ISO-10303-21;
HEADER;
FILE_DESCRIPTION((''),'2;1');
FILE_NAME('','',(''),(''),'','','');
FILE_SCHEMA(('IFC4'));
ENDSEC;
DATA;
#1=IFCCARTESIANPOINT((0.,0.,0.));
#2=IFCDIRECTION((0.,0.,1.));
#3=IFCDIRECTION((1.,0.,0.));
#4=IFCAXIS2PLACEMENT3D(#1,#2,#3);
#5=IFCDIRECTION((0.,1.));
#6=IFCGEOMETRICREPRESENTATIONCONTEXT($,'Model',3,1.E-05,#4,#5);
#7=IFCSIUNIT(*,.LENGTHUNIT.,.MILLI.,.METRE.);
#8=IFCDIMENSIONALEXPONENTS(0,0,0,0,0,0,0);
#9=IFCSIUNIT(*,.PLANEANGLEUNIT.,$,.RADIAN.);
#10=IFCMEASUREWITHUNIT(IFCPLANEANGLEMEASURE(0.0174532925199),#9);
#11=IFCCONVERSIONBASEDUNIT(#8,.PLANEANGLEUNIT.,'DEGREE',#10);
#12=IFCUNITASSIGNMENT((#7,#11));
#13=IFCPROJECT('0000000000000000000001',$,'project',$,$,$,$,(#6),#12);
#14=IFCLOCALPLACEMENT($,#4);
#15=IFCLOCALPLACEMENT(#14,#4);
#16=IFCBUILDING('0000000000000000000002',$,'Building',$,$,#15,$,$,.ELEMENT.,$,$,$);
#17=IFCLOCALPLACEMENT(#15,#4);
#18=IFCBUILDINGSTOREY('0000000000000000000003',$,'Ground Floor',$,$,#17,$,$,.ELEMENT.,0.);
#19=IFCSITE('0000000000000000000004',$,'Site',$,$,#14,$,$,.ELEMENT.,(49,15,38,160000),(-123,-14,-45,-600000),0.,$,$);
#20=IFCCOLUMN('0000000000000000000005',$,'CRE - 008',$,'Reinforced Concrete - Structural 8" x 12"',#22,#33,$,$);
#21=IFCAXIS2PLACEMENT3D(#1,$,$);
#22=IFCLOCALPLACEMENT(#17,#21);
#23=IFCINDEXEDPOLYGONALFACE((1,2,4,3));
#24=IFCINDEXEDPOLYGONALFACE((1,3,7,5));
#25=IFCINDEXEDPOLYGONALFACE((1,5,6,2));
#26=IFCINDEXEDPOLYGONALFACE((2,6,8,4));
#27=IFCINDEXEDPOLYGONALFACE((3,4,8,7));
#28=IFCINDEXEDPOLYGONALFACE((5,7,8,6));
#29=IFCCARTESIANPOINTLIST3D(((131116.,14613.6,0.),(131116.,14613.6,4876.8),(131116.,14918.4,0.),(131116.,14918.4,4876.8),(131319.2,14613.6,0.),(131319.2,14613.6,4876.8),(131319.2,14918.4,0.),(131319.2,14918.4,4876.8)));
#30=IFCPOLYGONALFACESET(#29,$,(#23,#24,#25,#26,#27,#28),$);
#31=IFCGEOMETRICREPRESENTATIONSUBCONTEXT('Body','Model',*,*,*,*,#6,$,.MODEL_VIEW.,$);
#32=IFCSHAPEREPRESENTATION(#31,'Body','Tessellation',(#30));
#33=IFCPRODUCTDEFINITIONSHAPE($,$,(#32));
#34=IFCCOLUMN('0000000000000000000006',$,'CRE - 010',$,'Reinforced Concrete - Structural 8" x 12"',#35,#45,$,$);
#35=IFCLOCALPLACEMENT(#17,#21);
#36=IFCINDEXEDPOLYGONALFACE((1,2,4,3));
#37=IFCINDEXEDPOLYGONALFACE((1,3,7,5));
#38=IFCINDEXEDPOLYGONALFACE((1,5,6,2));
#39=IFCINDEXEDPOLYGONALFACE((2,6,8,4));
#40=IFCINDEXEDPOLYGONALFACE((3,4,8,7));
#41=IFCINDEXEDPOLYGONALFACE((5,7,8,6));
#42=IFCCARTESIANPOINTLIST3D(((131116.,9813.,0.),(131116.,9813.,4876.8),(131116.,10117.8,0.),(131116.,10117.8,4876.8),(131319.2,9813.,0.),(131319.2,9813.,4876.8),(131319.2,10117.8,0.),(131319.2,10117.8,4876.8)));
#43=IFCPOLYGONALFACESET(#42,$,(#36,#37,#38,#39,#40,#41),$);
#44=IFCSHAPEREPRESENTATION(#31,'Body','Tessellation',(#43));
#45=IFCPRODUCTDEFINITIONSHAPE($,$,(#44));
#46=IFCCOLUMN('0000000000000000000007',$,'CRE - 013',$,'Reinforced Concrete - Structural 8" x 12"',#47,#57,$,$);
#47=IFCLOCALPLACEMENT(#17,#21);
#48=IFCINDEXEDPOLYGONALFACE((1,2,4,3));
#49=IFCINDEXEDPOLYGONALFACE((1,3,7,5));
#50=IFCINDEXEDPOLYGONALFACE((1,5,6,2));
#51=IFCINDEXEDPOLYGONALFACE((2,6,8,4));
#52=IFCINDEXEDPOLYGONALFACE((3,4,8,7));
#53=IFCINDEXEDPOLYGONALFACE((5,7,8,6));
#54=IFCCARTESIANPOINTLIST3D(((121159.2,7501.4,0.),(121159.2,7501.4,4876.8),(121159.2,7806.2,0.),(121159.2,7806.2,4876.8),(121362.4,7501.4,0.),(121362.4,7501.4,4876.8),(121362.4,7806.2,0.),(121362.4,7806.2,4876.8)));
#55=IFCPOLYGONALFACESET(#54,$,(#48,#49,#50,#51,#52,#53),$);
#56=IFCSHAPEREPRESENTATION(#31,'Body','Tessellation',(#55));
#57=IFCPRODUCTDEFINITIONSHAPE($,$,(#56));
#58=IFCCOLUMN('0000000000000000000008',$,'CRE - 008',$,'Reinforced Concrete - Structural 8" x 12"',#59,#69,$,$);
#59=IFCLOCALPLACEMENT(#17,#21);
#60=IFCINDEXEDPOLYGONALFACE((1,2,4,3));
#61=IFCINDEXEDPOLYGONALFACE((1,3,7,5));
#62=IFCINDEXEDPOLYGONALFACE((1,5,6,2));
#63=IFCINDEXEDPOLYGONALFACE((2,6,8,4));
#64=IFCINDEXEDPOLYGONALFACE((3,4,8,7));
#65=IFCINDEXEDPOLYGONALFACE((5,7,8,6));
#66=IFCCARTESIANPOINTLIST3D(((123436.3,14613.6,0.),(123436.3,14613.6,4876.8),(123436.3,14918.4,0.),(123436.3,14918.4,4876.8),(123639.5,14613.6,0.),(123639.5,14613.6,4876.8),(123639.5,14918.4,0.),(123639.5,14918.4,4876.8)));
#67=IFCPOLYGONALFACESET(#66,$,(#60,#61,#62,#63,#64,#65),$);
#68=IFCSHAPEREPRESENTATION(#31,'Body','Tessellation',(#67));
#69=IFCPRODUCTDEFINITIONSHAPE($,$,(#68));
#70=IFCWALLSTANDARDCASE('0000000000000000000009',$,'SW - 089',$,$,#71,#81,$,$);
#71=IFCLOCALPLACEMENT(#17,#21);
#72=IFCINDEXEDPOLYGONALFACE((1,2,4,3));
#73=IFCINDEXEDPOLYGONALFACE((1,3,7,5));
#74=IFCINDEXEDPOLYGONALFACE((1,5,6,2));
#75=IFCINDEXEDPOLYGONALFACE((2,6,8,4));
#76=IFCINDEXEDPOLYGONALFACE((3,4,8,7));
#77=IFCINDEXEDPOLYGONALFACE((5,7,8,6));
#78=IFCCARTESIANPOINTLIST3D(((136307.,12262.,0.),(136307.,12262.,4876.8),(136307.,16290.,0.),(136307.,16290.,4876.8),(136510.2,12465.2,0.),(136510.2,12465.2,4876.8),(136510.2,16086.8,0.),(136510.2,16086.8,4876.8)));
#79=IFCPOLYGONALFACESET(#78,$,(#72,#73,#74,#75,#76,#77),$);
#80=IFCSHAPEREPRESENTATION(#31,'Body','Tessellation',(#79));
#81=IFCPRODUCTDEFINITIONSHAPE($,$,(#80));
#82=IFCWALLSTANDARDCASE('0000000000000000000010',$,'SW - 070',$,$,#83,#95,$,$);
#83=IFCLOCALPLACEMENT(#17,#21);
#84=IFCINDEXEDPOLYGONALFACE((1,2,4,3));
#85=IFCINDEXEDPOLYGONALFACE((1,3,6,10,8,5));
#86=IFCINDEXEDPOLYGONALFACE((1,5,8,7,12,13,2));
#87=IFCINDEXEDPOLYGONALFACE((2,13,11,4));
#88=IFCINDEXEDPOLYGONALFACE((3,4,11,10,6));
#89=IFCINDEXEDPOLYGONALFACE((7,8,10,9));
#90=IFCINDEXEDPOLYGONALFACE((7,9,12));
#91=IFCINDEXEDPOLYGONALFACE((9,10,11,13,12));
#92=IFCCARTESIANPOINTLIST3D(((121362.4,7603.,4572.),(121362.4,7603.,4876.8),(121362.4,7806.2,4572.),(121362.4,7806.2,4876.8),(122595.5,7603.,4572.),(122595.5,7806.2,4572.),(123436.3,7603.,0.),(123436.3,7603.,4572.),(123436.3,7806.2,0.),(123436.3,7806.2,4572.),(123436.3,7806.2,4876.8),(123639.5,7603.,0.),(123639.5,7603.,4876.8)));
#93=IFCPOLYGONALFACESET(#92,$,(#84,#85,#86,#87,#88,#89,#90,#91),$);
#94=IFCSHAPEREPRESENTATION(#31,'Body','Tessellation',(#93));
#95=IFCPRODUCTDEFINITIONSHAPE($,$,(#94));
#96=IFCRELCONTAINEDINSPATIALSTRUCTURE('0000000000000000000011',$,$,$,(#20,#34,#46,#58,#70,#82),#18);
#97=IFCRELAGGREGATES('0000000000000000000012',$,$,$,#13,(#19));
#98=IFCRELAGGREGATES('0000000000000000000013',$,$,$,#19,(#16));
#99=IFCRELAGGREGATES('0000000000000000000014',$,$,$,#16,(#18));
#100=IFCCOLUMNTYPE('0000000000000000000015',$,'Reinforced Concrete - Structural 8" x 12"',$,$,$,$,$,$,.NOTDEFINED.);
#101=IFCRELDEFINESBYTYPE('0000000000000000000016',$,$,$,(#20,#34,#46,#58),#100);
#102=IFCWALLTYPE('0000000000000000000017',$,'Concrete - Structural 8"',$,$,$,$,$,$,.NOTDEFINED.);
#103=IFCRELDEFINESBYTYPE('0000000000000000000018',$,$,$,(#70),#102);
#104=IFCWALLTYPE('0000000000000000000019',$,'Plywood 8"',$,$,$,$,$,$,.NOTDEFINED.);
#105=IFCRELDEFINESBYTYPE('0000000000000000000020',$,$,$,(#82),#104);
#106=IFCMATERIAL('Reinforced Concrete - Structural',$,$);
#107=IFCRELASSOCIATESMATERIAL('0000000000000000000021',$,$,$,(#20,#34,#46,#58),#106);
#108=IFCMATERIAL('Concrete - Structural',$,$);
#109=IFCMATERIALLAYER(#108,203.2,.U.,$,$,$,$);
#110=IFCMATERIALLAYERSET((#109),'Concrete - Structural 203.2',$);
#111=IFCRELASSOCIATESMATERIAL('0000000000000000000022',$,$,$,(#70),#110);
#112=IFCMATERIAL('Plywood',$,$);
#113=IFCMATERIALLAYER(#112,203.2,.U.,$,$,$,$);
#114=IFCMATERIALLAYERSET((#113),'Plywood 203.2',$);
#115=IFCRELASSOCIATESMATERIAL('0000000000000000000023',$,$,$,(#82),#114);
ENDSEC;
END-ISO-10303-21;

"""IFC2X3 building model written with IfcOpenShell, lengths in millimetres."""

from ifc_helpers import new_model, entity, si_unit, converted_unit, direction, frame, origin_with_axes, origin_2d_with_axis, place, context, subcontext, project, spatial, polyline, rectangle, outline, extrude, material, layer, layer_set, layer_usage, type_object, element, save


model = new_model("IFC2X3")

# Units and contexts
model_context = context("Model", 3, precision=1e-05, world=origin_with_axes(), true_north=direction((0.0, 1.0)))
body_context = subcontext(model_context, "Body", "Model", "MODEL_VIEW")
ifc_project = project(units=[si_unit("LENGTHUNIT", "METRE", prefix="MILLI"), converted_unit("PLANEANGLEUNIT", "DEGREE", entity("IfcPlaneAngleMeasure", 0.0174532925199), si_unit("PLANEANGLEUNIT", "RADIAN"), dimensions=[0, 0, 0, 0, 0, 0, 0])], contexts=[model_context])

# Site, building, storey
site_placement = place(None, origin_with_axes())
site = spatial("IfcSite", under=ifc_project, at=site_placement, Name="Site", CompositionType="ELEMENT", RefLatitude=(49, 15, 38, 160000), RefLongitude=(-123, -14, -45, -600000), RefElevation=0.0)
building_placement = place(site_placement, origin_with_axes())
building = spatial("IfcBuilding", under=site, at=building_placement, Name="Building", CompositionType="ELEMENT")
storey_placement = place(building_placement, origin_with_axes())
storey = spatial("IfcBuildingStorey", under=building, at=storey_placement, Name="Ground Floor", CompositionType="ELEMENT", Elevation=0.0)

# Columns
ifc_material_1 = material(Name="Reinforced Concrete - Structural")
column_type = type_object("IfcColumnType", Name="Reinforced Concrete - Structural 8\" x 12\"", PredefinedType="NOTDEFINED")
for number, where, z_axis, x_axis, name in (
    (1, (131217.6, 14766.0, 0.0), (0.0, 0.0, 1.0), (1.0, 0.0, 0.0), "CRE - 008"),
    (2, (131217.6, 9965.4, 0.0), (0.0, 0.0, 1.0), (1.0, 0.0, 0.0), "CRE - 010"),
    (3, (121260.8, 7653.8, 0.0), (0.0, 0.0, 1.0), (1.0, 0.0, 0.0), "CRE - 013"),
    (4, (123537.9, 14766.0, 0.0), (0.0, 0.0, 1.0), (1.0, 0.0, 0.0), "CRE - 008"),
):
    element("IfcColumn", number, at=place(storey_placement, frame(where, z_axis=z_axis, x_axis=x_axis)), inside=storey, type_object=column_type, material=ifc_material_1, Name=name, ObjectType="Reinforced Concrete - Structural 8\" x 12\"", context=body_context, shape_type="SweptSolid", body=[
        extrude(rectangle(XDim=203.2, YDim=304.8, at=origin_2d_with_axis()), origin_with_axes(), (0.0, 0.0, 1.0), 4876.8),
    ])

# Wall
ifc_material_2 = material(Name="Concrete - Structural")
ifc_layer_1 = layer(ifc_material_2, 203.2, ventilated="UNKNOWN")
ifc_layer_set_1 = layer_set([ifc_layer_1], Name="Concrete - Structural 203.2")
ifc_layer_usage_1 = layer_usage(ifc_layer_set_1, "AXIS2", "POSITIVE", 0.0)
wall_type_1 = type_object("IfcWallType", Name="Concrete - Structural 8\"", PredefinedType="NOTDEFINED")
wall_1_placement = place(storey_placement, frame((136510.2, 12465.2, 0.0), z_axis=(0.0, 0.0, 1.0), x_axis=(0.0, 1.0, 0.0)))
element("IfcWallStandardCase", 5, at=wall_1_placement, inside=storey, type_object=wall_type_1, material=ifc_layer_usage_1, Name="SW - 089", context=body_context, shape_type="SweptSolid", body=[
    extrude(outline(polyline([(0.0, 0.0), (3621.6, 0.0), (3824.8, 203.2), (-203.2, 203.2), (0.0, 0.0)])), origin_with_axes(), (0.0, 0.0, 1.0), 4876.8),
])

# Wall, openings
ifc_material_3 = material(Name="Plywood")
ifc_layer_2 = layer(ifc_material_3, 203.2, ventilated="UNKNOWN")
ifc_layer_set_2 = layer_set([ifc_layer_2], Name="Plywood 203.2")
ifc_layer_usage_2 = layer_usage(ifc_layer_set_2, "AXIS2", "NEGATIVE", 0.0)
wall_type_2 = type_object("IfcWallType", Name="Plywood 8\"", PredefinedType="NOTDEFINED")
wall_2_placement = place(storey_placement, frame((123639.5, 7603.0, 0.0), z_axis=(0.0, 0.0, 1.0), x_axis=(-1.0, 0.0, 0.0)))
wall_2 = element("IfcWallStandardCase", 6, at=wall_2_placement, inside=storey, type_object=wall_type_2, material=ifc_layer_usage_2, Name="SW - 070", context=body_context, shape_type="SweptSolid", body=[
    extrude(outline(polyline([(203.2, -203.2), (2277.0, -203.2), (2277.0, 0.0), (0.0, 0.0), (203.2, -203.2)])), origin_with_axes(), (0.0, 0.0, 1.0), 4876.8),
])
opening_1_placement = place(wall_2_placement, frame((623.6, 0.0, 0.0), z_axis=(0.0, 0.0, 1.0), x_axis=(1.0, 0.0, 0.0)))
element("IfcOpeningElement", 7, at=opening_1_placement, cuts=wall_2, context=body_context, shape_type="SweptSolid", body=[
    extrude(rectangle(XDim=840.8, YDim=4572.0, at=origin_2d_with_axis()), frame((0.0, 203.2, 2286.0), z_axis=(0.0, 1.0, 0.0), x_axis=(1.0, 0.0, 0.0)), (0.0, 0.0, -1.0), 609.6),
])
opening_2_placement = place(wall_2_placement, frame((1660.5, 0.0, 0.0), z_axis=(0.0, 0.0, 1.0), x_axis=(1.0, 0.0, 0.0)))
element("IfcOpeningElement", 8, at=opening_2_placement, cuts=wall_2, context=body_context, shape_type="SweptSolid", body=[
    extrude(rectangle(XDim=1233.0, YDim=4572.0, at=origin_2d_with_axis()), frame((0.0, 203.2, 2286.0), z_axis=(0.0, -1.0, 0.0), x_axis=(-1.0, 0.0, 0.0)), (0.0, 0.0, 1.0), 609.6),
])

save(model, "model.ifc")
